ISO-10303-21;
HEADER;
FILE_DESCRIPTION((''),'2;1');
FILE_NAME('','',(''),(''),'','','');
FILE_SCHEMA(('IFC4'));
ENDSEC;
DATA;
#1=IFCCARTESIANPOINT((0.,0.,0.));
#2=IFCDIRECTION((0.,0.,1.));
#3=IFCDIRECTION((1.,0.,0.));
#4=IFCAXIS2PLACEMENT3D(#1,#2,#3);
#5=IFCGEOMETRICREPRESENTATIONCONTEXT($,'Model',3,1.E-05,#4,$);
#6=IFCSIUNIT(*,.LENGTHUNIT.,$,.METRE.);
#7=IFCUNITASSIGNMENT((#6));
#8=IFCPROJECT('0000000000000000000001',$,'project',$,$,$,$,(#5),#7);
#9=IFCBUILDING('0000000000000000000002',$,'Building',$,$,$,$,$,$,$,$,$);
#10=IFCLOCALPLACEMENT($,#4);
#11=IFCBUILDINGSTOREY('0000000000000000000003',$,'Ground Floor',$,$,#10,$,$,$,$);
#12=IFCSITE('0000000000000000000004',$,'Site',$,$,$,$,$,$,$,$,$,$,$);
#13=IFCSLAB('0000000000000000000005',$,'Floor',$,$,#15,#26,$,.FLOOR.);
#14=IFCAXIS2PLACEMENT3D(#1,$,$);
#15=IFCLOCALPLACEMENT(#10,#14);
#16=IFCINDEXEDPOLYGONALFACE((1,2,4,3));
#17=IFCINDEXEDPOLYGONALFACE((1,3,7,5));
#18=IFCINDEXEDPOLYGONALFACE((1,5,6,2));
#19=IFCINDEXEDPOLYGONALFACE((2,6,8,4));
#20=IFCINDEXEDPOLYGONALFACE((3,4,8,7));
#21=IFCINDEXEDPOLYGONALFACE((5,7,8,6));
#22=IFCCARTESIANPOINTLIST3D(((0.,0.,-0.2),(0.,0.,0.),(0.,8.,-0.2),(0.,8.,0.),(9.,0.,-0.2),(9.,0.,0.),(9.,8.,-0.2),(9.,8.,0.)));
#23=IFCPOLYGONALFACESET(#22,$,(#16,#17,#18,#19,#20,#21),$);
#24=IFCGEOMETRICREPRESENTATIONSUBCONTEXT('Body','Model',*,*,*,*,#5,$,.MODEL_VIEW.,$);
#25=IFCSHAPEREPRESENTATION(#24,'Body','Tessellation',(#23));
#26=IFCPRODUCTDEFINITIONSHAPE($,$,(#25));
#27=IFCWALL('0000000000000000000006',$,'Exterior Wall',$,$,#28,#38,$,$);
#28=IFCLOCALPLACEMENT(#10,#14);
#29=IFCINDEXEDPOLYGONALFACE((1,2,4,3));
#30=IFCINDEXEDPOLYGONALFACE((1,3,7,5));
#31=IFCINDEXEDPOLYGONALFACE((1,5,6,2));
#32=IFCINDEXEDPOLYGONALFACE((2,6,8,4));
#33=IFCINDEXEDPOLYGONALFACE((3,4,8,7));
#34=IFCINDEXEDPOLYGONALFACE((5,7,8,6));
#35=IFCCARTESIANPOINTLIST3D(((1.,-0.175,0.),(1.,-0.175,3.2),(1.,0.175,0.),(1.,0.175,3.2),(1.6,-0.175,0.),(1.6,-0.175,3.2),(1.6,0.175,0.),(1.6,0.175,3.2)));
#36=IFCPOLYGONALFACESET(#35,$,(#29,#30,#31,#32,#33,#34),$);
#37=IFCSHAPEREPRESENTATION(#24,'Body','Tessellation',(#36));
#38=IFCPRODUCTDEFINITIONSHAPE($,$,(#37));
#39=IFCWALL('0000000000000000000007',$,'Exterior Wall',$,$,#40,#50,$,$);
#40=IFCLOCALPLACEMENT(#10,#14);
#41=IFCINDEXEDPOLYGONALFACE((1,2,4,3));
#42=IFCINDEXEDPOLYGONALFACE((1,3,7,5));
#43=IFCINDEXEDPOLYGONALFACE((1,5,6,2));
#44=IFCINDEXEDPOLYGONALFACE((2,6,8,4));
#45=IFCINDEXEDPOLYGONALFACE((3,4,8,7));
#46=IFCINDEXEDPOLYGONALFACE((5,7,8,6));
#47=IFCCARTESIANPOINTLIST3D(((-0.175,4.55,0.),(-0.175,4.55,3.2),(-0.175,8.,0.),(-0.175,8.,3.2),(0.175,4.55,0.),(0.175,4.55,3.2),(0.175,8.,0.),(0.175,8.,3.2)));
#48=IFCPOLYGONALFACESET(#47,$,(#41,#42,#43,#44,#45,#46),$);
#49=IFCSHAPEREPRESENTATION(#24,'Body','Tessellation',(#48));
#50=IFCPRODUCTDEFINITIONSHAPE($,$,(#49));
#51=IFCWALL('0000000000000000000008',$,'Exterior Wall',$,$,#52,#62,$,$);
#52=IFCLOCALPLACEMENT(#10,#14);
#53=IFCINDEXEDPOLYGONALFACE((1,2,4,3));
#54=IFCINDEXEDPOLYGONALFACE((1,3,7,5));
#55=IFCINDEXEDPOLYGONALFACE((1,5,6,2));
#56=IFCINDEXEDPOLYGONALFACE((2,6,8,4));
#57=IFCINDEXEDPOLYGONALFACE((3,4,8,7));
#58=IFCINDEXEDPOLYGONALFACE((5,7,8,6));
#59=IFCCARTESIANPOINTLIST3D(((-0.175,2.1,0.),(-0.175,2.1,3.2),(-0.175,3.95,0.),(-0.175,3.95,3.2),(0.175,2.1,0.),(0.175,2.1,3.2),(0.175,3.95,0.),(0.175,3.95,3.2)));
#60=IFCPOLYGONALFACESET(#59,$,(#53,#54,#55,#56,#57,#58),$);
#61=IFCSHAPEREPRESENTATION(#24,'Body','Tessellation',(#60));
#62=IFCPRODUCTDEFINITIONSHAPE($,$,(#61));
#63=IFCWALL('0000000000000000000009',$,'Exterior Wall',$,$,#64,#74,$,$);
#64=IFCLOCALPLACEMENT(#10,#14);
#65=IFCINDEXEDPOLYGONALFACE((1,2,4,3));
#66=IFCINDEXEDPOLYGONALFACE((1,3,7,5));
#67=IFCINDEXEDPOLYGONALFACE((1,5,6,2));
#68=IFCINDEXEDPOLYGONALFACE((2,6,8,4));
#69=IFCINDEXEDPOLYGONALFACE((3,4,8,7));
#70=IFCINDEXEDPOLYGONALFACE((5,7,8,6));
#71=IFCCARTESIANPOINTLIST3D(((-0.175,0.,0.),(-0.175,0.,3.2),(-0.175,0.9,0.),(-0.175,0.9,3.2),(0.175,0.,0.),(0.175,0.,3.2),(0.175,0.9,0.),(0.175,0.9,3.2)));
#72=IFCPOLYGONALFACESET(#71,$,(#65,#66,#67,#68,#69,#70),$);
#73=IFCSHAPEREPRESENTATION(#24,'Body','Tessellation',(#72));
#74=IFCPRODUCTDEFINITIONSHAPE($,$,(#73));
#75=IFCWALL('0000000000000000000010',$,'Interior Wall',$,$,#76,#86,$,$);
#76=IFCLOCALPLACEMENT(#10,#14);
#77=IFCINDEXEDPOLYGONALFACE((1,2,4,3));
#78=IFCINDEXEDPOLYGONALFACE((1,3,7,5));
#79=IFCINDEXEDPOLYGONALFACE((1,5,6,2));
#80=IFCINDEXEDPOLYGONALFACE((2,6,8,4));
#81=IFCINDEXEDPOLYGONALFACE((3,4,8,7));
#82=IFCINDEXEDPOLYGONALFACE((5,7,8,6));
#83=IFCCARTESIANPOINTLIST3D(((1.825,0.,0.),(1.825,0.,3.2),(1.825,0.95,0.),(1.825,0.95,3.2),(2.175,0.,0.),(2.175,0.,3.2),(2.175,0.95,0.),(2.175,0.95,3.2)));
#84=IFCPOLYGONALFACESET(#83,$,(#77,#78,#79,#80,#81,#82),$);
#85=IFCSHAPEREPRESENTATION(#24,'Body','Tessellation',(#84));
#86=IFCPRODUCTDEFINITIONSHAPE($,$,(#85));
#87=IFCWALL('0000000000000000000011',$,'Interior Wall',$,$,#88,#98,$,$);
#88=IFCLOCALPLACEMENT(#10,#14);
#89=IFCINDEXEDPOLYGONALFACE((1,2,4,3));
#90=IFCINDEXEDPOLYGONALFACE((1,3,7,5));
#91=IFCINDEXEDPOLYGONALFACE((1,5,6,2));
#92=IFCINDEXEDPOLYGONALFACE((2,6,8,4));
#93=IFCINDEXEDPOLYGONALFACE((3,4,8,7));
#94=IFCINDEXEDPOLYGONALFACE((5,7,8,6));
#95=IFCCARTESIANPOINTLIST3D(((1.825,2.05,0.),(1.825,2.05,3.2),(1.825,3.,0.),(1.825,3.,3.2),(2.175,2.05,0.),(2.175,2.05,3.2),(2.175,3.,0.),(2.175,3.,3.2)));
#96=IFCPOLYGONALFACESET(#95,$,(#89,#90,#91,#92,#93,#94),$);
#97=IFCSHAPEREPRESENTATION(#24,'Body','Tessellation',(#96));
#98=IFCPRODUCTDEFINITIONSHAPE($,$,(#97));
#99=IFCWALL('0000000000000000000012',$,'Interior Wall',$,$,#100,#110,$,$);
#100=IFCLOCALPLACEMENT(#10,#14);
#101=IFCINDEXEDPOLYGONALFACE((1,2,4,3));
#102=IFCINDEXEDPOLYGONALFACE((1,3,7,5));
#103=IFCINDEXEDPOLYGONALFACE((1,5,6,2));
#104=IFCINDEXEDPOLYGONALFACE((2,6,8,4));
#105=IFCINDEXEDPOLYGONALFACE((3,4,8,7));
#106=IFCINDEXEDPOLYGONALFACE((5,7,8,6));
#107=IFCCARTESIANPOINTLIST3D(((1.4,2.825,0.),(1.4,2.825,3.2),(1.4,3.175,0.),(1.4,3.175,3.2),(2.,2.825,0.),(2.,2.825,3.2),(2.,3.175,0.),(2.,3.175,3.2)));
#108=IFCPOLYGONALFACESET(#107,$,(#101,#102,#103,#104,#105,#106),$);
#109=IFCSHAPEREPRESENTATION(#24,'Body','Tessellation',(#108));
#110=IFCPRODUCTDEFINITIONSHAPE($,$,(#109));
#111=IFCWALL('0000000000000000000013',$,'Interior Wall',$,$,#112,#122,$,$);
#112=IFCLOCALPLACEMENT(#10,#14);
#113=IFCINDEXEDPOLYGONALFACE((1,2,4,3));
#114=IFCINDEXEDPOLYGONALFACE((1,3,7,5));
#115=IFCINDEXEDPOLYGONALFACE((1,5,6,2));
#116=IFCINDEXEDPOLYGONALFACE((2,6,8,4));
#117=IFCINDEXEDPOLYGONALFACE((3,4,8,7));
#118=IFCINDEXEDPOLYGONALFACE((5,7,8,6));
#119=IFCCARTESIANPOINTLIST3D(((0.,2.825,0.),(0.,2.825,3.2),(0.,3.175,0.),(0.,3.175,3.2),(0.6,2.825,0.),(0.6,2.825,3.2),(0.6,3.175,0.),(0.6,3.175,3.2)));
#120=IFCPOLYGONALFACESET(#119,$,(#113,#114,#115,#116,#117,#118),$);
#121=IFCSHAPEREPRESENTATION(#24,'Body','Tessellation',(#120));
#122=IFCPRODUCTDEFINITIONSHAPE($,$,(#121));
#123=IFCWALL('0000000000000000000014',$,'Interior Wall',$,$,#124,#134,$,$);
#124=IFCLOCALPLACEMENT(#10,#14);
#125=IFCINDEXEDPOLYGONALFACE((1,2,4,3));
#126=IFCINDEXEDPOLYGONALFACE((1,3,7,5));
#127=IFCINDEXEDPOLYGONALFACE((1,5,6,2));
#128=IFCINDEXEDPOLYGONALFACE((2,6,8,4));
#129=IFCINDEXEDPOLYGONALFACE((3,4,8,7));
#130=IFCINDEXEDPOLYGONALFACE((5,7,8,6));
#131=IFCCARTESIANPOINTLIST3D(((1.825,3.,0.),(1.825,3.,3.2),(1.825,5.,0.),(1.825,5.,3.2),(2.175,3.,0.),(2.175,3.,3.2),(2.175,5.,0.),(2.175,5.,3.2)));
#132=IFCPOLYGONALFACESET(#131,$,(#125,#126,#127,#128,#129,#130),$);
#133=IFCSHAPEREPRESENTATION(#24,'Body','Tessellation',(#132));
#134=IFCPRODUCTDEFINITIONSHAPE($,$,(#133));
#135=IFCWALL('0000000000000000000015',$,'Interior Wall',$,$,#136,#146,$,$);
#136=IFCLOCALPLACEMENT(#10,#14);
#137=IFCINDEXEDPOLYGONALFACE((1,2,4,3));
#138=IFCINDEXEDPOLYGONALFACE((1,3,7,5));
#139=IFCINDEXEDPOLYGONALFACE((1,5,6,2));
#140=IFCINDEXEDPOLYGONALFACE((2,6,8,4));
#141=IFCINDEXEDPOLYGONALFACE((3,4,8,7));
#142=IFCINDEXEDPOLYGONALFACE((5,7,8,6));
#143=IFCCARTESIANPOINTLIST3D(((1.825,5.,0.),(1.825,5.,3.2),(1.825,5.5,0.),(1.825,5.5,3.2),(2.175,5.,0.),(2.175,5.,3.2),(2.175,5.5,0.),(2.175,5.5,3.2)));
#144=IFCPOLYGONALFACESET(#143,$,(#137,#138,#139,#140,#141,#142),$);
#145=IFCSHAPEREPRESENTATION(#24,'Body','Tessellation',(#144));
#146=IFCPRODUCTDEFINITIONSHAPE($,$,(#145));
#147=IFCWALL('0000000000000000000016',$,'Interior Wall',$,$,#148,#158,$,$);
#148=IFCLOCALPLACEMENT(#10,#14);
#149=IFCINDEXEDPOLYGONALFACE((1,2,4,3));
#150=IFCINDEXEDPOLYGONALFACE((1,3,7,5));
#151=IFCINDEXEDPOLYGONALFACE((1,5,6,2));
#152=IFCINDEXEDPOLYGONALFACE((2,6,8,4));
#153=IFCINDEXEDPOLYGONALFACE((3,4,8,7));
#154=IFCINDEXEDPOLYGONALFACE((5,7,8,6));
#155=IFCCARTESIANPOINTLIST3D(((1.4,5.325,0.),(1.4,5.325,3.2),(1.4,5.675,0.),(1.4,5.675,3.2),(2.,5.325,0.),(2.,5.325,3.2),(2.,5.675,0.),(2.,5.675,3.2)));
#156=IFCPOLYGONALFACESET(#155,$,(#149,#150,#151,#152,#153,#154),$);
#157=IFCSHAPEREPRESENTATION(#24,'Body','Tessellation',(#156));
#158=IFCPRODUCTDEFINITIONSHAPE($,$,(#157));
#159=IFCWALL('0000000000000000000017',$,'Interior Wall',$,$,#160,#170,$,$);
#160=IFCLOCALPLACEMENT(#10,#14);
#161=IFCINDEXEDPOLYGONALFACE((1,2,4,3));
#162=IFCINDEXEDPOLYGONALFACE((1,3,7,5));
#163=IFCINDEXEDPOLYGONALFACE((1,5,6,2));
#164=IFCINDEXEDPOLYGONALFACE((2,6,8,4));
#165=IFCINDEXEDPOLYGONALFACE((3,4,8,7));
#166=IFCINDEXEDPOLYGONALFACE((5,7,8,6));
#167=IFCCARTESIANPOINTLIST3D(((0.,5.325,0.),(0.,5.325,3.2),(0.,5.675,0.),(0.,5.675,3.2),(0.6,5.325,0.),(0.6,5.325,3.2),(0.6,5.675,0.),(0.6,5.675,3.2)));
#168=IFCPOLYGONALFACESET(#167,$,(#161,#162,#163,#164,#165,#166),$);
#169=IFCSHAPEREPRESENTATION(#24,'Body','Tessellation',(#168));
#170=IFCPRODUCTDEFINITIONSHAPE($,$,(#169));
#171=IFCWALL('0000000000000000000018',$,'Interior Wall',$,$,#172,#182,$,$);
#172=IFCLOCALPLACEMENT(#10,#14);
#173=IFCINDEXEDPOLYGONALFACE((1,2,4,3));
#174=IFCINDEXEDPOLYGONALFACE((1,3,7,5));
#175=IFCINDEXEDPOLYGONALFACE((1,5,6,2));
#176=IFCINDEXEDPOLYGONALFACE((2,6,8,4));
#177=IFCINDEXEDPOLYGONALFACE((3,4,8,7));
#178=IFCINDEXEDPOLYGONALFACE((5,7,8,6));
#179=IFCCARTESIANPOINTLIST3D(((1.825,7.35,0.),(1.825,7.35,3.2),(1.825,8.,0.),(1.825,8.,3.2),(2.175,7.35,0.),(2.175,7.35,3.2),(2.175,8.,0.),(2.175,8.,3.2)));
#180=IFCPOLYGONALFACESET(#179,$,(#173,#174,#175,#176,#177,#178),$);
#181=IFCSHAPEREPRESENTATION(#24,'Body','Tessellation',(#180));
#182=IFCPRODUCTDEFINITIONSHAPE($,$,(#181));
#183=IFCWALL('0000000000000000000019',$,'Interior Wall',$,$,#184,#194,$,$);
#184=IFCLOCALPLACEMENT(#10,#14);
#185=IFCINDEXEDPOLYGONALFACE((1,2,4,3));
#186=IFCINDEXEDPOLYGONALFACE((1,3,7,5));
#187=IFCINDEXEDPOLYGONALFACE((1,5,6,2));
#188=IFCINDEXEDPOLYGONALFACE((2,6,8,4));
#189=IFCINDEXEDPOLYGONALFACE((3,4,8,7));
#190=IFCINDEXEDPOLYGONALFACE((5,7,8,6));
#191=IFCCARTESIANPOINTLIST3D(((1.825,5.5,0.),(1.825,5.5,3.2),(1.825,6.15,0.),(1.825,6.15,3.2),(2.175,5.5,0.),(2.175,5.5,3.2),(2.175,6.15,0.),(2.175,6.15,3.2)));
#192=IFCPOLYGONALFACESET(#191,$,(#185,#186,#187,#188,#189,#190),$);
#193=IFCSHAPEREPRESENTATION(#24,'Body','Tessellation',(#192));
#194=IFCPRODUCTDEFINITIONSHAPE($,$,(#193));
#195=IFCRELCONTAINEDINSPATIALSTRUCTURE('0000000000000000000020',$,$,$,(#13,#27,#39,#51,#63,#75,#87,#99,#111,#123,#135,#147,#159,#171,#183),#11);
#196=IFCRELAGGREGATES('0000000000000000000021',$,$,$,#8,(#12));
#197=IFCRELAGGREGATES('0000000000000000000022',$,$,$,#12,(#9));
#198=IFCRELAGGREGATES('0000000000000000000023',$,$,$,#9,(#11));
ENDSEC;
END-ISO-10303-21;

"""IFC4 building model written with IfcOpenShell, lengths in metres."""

from ifc_helpers import new_model, si_unit, frame, origin_with_axes, place, context, subcontext, project, spatial, indexed_curve, outline, extrude, element, save


model = new_model("IFC4")

# Units and contexts
model_context = context("Model", 3, precision=1e-05, world=origin_with_axes())
body_context = subcontext(model_context, "Body", "Model", "MODEL_VIEW")
ifc_project = project(units=[si_unit("LENGTHUNIT", "METRE")], contexts=[model_context])

# Site, building, storey
site = spatial("IfcSite", under=ifc_project, Name="Site")
building = spatial("IfcBuilding", under=site, Name="Building")
storey_placement = place(None, origin_with_axes())
storey = spatial("IfcBuildingStorey", under=building, at=storey_placement, Name="Ground Floor")

# Slab
slab_placement = place(storey_placement, frame((0.0, 0.0, -0.2), z_axis=(0.0, 0.0, 1.0), x_axis=(1.0, 0.0, 0.0)))
element("IfcSlab", 1, at=slab_placement, inside=storey, Name="Floor", PredefinedType="FLOOR", context=body_context, shape_type="SweptSolid", body=[
    extrude(outline(indexed_curve([(0.0, 0.0), (9.0, 0.0), (9.0, 8.0), (0.0, 8.0)])), None, (0.0, 0.0, 1.0), 0.2),
])

# Walls
wall_1_placement = place(storey_placement, frame((1.0, 0.0, 0.0), z_axis=(0.0, 0.0, 1.0), x_axis=(1.0, 0.0, 0.0)))
element("IfcWall", 2, at=wall_1_placement, inside=storey, Name="Exterior Wall", context=body_context, shape_type="SweptSolid", body=[
    extrude(outline(indexed_curve([(0.0, 0.0), (0.0, 0.35), (0.6, 0.35), (0.6, 0.0), (0.0, 0.0)], self_intersect=False)), frame((0.0, -0.175, 0.0), z_axis=(0.0, 0.0, 1.0), x_axis=(1.0, 0.0, 0.0)), (0.0, 0.0, 1.0), 3.2),
])
wall_2_placement = place(storey_placement, frame((0.0, 8.0, 0.0), z_axis=(0.0, 0.0, 1.0), x_axis=(0.0, -1.0, 0.0)))
element("IfcWall", 3, at=wall_2_placement, inside=storey, Name="Exterior Wall", context=body_context, shape_type="SweptSolid", body=[
    extrude(outline(indexed_curve([(0.0, 0.0), (0.0, 0.35), (3.45, 0.35), (3.45, 0.0), (0.0, 0.0)], self_intersect=False)), frame((0.0, -0.175, 0.0), z_axis=(0.0, 0.0, 1.0), x_axis=(1.0, 0.0, 0.0)), (0.0, 0.0, 1.0), 3.2),
])
wall_3_placement = place(storey_placement, frame((0.0, 3.95, 0.0), z_axis=(0.0, 0.0, 1.0), x_axis=(0.0, -1.0, 0.0)))
element("IfcWall", 4, at=wall_3_placement, inside=storey, Name="Exterior Wall", context=body_context, shape_type="SweptSolid", body=[
    extrude(outline(indexed_curve([(0.0, 0.0), (0.0, 0.35), (1.85, 0.35), (1.85, 0.0), (0.0, 0.0)], self_intersect=False)), frame((0.0, -0.175, 0.0), z_axis=(0.0, 0.0, 1.0), x_axis=(1.0, 0.0, 0.0)), (0.0, 0.0, 1.0), 3.2),
])
wall_4_placement = place(storey_placement, frame((0.0, 0.9, 0.0), z_axis=(0.0, 0.0, 1.0), x_axis=(0.0, -1.0, 0.0)))
element("IfcWall", 5, at=wall_4_placement, inside=storey, Name="Exterior Wall", context=body_context, shape_type="SweptSolid", body=[
    extrude(outline(indexed_curve([(0.0, 0.0), (0.0, 0.35), (0.9, 0.35), (0.9, 0.0), (0.0, 0.0)], self_intersect=False)), frame((0.0, -0.175, 0.0), z_axis=(0.0, 0.0, 1.0), x_axis=(1.0, 0.0, 0.0)), (0.0, 0.0, 1.0), 3.2),
])
wall_5_placement = place(storey_placement, frame((2.0, 0.0, 0.0), z_axis=(0.0, 0.0, 1.0), x_axis=(0.0, 1.0, 0.0)))
element("IfcWall", 6, at=wall_5_placement, inside=storey, Name="Interior Wall", context=body_context, shape_type="SweptSolid", body=[
    extrude(outline(indexed_curve([(0.0, 0.0), (0.0, 0.35), (0.95, 0.35), (0.95, 0.0), (0.0, 0.0)], self_intersect=False)), frame((0.0, -0.175, 0.0), z_axis=(0.0, 0.0, 1.0), x_axis=(1.0, 0.0, 0.0)), (0.0, 0.0, 1.0), 3.2),
])
wall_6_placement = place(storey_placement, frame((2.0, 2.05, 0.0), z_axis=(0.0, 0.0, 1.0), x_axis=(0.0, 1.0, 0.0)))
element("IfcWall", 7, at=wall_6_placement, inside=storey, Name="Interior Wall", context=body_context, shape_type="SweptSolid", body=[
    extrude(outline(indexed_curve([(0.0, 0.0), (0.0, 0.35), (0.95, 0.35), (0.95, 0.0), (0.0, 0.0)], self_intersect=False)), frame((0.0, -0.175, 0.0), z_axis=(0.0, 0.0, 1.0), x_axis=(1.0, 0.0, 0.0)), (0.0, 0.0, 1.0), 3.2),
])
for number, where, z_axis, x_axis, name in (
    (8, (2.0, 3.0, 0.0), (0.0, 0.0, 1.0), (-1.0, 0.0, 0.0), "Interior Wall"),
    (9, (0.6, 3.0, 0.0), (0.0, 0.0, 1.0), (-1.0, 0.0, 0.0), "Interior Wall"),
):
    element("IfcWall", number, at=place(storey_placement, frame(where, z_axis=z_axis, x_axis=x_axis)), inside=storey, Name=name, context=body_context, shape_type="SweptSolid", body=[
        extrude(outline(indexed_curve([(0.0, 0.0), (0.0, 0.35), (0.6, 0.35), (0.6, 0.0), (0.0, 0.0)], self_intersect=False)), frame((0.0, -0.175, 0.0), z_axis=(0.0, 0.0, 1.0), x_axis=(1.0, 0.0, 0.0)), (0.0, 0.0, 1.0), 3.2),
    ])
wall_7_placement = place(storey_placement, frame((2.0, 5.0, 0.0), z_axis=(0.0, 0.0, 1.0), x_axis=(0.0, -1.0, 0.0)))
element("IfcWall", 10, at=wall_7_placement, inside=storey, Name="Interior Wall", context=body_context, shape_type="SweptSolid", body=[
    extrude(outline(indexed_curve([(0.0, 0.0), (0.0, 0.35), (2.0, 0.35), (2.0, 0.0), (0.0, 0.0)], self_intersect=False)), frame((0.0, -0.175, 0.0), z_axis=(0.0, 0.0, 1.0), x_axis=(1.0, 0.0, 0.0)), (0.0, 0.0, 1.0), 3.2),
])
wall_8_placement = place(storey_placement, frame((2.0, 5.0, 0.0), z_axis=(0.0, 0.0, 1.0), x_axis=(0.0, 1.0, 0.0)))
element("IfcWall", 11, at=wall_8_placement, inside=storey, Name="Interior Wall", context=body_context, shape_type="SweptSolid", body=[
    extrude(outline(indexed_curve([(0.0, 0.0), (0.0, 0.35), (0.5, 0.35), (0.5, 0.0), (0.0, 0.0)], self_intersect=False)), frame((0.0, -0.175, 0.0), z_axis=(0.0, 0.0, 1.0), x_axis=(1.0, 0.0, 0.0)), (0.0, 0.0, 1.0), 3.2),
])
for number, where, z_axis, x_axis, name in (
    (12, (2.0, 5.5, 0.0), (0.0, 0.0, 1.0), (-1.0, 0.0, 0.0), "Interior Wall"),
    (13, (0.6, 5.5, 0.0), (0.0, 0.0, 1.0), (-1.0, 0.0, 0.0), "Interior Wall"),
):
    element("IfcWall", number, at=place(storey_placement, frame(where, z_axis=z_axis, x_axis=x_axis)), inside=storey, Name=name, context=body_context, shape_type="SweptSolid", body=[
        extrude(outline(indexed_curve([(0.0, 0.0), (0.0, 0.35), (0.6, 0.35), (0.6, 0.0), (0.0, 0.0)], self_intersect=False)), frame((0.0, -0.175, 0.0), z_axis=(0.0, 0.0, 1.0), x_axis=(1.0, 0.0, 0.0)), (0.0, 0.0, 1.0), 3.2),
    ])
for number, where, z_axis, x_axis, name in (
    (14, (2.0, 8.0, 0.0), (0.0, 0.0, 1.0), (0.0, -1.0, 0.0), "Interior Wall"),
    (15, (2.0, 6.15, 0.0), (0.0, 0.0, 1.0), (0.0, -1.0, 0.0), "Interior Wall"),
):
    element("IfcWall", number, at=place(storey_placement, frame(where, z_axis=z_axis, x_axis=x_axis)), inside=storey, Name=name, context=body_context, shape_type="SweptSolid", body=[
        extrude(outline(indexed_curve([(0.0, 0.0), (0.0, 0.35), (0.65, 0.35), (0.65, 0.0), (0.0, 0.0)], self_intersect=False)), frame((0.0, -0.175, 0.0), z_axis=(0.0, 0.0, 1.0), x_axis=(1.0, 0.0, 0.0)), (0.0, 0.0, 1.0), 3.2),
    ])

save(model, "model.ifc")
